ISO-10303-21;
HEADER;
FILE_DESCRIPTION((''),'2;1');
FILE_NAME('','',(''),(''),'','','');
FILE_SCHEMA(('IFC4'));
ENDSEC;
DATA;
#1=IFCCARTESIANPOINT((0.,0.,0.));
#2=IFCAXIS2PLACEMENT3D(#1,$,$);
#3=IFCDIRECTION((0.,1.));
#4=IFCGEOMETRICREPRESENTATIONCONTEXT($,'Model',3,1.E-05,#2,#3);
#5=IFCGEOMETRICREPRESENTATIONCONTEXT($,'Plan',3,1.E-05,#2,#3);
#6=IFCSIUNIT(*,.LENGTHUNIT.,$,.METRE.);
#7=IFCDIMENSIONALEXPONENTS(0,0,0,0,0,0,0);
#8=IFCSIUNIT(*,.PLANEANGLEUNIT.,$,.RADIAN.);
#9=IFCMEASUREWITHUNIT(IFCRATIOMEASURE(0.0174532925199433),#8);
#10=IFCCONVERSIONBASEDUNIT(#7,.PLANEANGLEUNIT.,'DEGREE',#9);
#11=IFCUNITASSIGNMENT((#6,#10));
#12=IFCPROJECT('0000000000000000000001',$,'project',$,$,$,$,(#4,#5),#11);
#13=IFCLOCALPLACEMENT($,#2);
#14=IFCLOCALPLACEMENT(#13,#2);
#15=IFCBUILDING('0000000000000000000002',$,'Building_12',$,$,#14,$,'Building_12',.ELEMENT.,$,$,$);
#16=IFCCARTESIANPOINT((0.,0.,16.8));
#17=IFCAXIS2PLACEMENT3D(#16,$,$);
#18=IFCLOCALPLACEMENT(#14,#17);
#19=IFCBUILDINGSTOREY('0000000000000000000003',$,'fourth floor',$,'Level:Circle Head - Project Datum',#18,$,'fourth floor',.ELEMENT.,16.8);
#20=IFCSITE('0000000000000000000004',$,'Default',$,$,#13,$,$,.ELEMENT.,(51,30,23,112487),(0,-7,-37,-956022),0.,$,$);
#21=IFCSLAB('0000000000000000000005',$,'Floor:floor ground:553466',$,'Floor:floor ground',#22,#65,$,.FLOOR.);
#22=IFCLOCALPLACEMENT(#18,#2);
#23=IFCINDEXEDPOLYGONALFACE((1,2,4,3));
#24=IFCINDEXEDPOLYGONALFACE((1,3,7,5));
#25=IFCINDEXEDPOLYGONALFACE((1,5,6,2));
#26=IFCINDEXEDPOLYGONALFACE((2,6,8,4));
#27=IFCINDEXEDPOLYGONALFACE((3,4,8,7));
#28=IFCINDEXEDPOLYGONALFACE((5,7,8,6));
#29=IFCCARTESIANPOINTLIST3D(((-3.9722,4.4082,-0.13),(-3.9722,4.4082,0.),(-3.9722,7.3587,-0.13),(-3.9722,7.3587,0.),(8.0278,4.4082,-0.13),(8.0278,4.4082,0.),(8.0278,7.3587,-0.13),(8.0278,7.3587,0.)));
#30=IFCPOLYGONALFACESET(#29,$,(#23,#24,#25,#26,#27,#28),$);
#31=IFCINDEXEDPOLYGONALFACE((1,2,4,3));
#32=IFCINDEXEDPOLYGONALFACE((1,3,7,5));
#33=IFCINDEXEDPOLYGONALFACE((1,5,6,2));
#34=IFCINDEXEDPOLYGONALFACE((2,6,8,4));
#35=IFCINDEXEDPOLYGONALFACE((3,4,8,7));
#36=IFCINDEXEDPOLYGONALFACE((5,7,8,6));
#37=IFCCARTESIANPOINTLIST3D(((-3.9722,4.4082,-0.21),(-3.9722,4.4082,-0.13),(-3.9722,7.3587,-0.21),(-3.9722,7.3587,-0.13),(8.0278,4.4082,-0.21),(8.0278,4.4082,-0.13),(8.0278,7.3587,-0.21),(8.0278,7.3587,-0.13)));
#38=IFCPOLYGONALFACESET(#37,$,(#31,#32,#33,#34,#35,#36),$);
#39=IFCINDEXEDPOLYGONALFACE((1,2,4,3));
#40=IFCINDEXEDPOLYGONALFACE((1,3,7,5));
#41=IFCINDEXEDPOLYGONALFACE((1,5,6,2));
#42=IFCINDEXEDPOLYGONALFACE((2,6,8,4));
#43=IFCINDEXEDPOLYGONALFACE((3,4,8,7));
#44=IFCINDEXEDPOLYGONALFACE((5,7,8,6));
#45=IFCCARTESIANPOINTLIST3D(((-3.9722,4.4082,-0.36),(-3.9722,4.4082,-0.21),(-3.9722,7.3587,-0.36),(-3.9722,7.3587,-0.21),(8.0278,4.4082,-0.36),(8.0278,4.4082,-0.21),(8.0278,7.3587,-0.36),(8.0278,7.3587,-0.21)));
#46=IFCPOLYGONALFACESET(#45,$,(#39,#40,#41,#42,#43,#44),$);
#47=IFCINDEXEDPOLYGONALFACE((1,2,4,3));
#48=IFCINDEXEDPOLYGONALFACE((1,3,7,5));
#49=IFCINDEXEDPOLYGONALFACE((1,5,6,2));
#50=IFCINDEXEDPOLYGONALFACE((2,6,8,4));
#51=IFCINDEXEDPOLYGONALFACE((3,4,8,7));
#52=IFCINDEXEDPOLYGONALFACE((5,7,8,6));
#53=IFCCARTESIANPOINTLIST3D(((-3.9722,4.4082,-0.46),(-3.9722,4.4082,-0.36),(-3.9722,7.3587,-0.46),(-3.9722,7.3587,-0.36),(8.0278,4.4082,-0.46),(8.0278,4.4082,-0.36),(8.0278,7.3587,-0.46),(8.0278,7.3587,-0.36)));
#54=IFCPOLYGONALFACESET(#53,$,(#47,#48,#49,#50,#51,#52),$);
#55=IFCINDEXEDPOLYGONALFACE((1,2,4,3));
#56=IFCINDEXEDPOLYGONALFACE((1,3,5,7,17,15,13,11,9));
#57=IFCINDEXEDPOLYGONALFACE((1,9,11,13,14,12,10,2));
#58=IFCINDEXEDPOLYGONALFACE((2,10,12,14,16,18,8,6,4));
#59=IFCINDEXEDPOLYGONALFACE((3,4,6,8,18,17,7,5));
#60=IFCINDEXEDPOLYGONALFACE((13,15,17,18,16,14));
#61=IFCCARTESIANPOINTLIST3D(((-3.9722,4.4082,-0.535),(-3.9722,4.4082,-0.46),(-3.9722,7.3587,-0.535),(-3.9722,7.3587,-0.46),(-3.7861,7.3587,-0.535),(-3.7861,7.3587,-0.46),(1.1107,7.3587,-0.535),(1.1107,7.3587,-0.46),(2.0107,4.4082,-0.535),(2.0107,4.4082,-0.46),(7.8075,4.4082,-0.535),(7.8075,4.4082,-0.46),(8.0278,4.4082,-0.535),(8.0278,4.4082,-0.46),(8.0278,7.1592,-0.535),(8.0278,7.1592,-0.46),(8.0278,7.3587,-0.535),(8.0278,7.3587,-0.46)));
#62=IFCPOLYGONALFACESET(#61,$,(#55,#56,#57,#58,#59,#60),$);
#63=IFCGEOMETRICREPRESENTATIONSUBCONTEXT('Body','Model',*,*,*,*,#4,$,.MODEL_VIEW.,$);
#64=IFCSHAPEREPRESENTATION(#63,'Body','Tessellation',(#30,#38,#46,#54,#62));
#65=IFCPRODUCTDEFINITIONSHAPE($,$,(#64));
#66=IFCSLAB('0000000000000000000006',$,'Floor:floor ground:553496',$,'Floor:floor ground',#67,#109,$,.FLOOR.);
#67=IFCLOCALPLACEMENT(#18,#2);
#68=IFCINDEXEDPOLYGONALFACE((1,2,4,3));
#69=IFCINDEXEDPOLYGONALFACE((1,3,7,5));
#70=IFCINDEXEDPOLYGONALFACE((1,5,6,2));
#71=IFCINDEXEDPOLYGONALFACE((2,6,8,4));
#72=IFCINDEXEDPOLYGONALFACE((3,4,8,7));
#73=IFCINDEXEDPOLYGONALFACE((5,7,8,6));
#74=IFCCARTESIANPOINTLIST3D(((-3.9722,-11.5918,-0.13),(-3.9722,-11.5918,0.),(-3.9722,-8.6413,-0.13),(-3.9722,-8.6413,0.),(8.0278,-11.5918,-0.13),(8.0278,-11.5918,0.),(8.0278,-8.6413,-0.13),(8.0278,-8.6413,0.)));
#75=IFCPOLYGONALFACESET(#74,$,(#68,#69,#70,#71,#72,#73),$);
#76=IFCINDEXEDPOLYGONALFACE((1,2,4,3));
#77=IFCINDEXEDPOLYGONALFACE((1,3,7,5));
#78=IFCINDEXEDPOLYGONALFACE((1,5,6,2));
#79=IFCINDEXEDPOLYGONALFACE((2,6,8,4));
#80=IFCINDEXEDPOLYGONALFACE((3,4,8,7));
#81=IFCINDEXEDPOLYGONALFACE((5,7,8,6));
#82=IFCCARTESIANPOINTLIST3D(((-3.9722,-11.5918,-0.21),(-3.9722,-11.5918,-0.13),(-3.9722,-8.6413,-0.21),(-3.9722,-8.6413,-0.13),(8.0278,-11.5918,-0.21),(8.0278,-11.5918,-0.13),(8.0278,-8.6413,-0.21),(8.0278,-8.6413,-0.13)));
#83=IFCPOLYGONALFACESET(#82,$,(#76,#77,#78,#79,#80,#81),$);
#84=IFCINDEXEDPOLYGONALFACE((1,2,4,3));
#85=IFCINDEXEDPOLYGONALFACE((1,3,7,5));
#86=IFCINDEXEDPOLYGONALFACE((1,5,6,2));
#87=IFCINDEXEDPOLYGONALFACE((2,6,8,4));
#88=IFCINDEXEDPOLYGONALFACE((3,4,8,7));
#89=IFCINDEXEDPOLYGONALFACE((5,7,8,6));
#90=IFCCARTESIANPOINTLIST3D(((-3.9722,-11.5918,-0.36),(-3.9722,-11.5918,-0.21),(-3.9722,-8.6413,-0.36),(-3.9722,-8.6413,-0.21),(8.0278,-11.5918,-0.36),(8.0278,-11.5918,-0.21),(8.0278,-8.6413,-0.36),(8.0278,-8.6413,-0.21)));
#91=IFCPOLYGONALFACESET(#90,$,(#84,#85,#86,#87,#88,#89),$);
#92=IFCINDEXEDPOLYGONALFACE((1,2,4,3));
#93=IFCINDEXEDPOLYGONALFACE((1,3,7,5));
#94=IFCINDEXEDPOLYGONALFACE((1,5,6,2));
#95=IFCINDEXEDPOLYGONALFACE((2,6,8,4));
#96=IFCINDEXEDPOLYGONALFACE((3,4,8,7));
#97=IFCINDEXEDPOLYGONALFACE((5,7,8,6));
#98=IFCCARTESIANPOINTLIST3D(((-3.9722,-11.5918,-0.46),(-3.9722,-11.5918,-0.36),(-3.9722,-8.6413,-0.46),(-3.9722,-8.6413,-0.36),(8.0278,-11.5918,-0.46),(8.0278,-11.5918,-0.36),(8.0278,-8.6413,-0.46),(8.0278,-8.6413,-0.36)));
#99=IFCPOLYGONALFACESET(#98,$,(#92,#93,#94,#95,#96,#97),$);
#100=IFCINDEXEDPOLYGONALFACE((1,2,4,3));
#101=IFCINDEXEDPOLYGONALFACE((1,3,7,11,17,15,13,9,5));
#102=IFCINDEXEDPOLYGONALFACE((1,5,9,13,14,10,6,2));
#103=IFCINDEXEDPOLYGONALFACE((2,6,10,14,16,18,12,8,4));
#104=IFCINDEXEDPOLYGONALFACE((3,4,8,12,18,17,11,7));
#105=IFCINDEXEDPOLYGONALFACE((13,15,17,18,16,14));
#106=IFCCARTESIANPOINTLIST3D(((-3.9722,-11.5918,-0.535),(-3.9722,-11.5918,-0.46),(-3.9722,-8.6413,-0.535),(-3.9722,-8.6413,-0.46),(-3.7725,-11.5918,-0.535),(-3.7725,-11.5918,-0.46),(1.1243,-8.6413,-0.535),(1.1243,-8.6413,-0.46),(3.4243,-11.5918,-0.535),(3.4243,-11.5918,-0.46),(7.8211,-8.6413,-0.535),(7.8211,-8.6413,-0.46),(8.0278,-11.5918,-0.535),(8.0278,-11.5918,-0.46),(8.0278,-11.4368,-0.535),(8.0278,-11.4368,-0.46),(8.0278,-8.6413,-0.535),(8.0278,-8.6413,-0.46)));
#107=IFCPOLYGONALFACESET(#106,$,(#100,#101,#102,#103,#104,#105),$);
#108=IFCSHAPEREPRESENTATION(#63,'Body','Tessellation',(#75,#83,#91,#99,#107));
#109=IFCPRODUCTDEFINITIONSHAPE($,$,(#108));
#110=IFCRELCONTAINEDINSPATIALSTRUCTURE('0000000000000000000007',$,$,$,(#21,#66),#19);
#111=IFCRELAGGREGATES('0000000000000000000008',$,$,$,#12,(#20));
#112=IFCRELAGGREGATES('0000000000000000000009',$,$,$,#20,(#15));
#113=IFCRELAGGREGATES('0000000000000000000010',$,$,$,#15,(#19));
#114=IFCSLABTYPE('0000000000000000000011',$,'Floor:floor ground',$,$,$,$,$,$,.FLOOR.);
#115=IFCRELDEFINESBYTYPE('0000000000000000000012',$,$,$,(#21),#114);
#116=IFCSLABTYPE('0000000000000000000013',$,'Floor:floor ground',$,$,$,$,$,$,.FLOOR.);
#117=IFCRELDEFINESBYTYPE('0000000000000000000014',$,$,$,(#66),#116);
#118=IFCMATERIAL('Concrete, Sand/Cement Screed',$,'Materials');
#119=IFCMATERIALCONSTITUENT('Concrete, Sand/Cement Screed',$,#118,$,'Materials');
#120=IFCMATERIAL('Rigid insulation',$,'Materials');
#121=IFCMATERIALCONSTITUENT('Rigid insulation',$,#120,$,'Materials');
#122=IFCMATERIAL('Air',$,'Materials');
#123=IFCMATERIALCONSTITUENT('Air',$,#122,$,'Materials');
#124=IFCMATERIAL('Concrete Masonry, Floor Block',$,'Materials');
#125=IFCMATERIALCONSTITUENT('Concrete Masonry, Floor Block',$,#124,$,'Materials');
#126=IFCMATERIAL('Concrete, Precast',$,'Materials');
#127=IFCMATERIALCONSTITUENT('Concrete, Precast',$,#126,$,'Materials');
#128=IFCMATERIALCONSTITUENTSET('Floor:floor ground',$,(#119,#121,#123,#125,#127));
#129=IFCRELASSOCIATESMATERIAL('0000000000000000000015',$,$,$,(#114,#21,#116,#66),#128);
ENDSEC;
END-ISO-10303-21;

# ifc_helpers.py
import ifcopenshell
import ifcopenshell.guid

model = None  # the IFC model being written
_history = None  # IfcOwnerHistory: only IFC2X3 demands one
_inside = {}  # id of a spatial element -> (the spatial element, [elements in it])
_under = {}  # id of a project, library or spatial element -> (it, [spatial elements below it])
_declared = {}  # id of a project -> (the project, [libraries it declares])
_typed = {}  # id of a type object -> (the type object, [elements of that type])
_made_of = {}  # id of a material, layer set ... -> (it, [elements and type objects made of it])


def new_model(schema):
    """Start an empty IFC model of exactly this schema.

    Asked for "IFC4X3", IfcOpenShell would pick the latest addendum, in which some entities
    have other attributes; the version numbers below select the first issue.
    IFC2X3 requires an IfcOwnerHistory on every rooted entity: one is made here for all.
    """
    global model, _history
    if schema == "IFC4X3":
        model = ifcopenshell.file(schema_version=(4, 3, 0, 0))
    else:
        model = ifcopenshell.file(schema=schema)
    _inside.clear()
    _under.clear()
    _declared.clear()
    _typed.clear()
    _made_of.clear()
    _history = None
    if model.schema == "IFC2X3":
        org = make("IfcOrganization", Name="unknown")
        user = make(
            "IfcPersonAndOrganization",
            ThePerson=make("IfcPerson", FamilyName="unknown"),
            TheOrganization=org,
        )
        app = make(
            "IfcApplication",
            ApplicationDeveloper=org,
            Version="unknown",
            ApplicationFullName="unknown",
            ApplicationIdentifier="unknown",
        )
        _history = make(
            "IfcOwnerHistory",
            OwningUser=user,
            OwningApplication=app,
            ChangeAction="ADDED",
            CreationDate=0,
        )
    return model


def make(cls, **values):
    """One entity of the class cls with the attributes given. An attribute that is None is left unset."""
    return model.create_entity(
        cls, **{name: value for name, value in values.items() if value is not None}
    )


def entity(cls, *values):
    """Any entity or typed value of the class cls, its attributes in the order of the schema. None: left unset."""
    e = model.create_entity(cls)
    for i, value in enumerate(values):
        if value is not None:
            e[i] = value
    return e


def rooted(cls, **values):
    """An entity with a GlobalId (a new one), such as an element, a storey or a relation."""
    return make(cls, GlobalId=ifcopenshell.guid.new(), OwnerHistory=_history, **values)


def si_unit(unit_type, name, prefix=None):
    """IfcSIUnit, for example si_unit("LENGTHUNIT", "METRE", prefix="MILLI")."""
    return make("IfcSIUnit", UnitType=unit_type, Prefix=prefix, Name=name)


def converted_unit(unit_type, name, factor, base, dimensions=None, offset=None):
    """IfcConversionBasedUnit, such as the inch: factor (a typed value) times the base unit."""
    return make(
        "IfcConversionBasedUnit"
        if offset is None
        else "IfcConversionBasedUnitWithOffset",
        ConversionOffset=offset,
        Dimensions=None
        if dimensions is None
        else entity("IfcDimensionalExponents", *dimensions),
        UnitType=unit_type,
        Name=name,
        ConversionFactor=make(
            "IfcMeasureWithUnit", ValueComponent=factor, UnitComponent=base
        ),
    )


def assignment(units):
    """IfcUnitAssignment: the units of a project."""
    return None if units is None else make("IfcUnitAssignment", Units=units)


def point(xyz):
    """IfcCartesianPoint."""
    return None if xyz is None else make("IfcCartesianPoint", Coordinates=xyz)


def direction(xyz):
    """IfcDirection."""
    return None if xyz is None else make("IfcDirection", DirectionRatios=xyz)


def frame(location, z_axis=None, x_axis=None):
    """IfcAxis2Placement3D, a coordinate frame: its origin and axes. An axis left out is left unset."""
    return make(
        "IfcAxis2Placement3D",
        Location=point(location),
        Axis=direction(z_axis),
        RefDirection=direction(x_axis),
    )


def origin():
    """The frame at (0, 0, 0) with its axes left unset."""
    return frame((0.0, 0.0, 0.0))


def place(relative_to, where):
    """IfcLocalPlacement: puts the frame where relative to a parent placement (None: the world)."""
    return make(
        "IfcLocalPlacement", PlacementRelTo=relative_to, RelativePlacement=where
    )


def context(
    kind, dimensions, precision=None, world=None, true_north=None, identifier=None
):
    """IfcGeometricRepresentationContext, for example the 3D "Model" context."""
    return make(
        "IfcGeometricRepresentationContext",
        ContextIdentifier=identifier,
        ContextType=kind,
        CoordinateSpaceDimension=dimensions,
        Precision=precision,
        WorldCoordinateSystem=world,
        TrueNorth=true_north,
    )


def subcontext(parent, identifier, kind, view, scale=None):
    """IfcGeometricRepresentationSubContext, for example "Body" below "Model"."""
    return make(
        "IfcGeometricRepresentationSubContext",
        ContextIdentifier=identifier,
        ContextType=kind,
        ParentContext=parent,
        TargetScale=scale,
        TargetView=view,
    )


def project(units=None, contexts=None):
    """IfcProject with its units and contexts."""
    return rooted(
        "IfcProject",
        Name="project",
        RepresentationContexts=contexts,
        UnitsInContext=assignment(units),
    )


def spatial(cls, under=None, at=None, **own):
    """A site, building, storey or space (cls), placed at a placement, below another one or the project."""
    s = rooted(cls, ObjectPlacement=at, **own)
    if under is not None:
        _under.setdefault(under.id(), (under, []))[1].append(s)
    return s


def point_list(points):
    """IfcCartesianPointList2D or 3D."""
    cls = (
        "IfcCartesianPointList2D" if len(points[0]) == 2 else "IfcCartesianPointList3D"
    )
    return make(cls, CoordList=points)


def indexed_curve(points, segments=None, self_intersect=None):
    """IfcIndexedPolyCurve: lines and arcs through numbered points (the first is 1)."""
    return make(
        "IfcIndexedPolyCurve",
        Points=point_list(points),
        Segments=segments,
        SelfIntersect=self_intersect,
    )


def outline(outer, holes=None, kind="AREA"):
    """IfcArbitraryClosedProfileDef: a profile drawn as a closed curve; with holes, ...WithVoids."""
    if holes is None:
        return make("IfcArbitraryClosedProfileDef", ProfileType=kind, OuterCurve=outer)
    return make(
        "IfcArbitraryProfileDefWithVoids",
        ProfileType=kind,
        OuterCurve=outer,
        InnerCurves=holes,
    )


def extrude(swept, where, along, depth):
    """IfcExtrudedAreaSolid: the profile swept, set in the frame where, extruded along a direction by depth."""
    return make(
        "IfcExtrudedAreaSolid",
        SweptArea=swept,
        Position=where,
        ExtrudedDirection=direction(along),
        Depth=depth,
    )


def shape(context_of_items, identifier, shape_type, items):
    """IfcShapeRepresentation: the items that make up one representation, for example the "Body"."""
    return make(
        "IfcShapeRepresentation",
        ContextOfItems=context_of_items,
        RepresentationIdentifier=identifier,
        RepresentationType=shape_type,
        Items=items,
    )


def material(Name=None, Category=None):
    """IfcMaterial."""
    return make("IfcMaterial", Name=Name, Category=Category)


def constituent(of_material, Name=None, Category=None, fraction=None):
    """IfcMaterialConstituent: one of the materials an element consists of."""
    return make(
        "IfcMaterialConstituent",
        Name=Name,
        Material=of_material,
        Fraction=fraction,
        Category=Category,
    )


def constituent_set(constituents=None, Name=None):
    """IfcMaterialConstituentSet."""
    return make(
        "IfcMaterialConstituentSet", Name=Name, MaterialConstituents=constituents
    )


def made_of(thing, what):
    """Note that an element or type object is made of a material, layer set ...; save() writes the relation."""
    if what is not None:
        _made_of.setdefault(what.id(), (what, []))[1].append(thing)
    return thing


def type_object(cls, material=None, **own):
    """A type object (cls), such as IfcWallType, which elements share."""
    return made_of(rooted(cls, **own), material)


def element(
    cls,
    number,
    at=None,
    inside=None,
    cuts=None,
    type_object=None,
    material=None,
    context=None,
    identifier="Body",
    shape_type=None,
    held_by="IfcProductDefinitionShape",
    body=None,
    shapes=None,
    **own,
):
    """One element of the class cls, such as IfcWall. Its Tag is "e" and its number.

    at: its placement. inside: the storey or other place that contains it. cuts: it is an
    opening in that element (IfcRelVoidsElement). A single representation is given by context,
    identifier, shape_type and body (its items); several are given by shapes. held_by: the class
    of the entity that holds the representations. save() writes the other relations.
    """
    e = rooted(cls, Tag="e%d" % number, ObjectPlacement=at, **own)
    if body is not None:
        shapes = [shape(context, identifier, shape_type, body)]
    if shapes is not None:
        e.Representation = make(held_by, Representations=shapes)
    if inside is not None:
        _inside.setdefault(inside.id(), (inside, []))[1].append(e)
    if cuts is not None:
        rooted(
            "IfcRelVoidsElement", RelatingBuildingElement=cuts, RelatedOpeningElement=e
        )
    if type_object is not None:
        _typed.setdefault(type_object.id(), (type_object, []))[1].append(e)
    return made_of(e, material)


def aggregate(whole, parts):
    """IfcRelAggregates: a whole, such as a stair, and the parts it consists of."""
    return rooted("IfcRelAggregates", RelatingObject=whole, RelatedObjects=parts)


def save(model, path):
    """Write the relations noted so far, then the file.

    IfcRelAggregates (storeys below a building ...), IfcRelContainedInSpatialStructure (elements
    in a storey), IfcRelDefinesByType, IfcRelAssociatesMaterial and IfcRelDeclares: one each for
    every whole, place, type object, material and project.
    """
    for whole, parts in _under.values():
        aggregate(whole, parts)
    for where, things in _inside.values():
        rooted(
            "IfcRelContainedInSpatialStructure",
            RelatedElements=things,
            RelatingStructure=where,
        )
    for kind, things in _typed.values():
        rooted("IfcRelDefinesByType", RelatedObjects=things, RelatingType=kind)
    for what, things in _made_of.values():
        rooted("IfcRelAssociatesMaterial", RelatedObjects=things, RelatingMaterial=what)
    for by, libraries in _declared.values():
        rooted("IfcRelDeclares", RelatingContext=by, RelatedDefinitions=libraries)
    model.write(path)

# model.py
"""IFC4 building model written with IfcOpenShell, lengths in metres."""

from ifc_helpers import new_model, entity, si_unit, converted_unit, direction, frame, origin, place, context, subcontext, project, spatial, indexed_curve, outline, extrude, material, constituent, constituent_set, type_object, element, save


model = new_model("IFC4")

# Units and contexts
model_context = context("Model", 3, precision=1e-05, world=origin(), true_north=direction((0.0, 1.0)))
plan_context = context("Plan", 3, precision=1e-05, world=origin(), true_north=direction((0.0, 1.0)))
body_context = subcontext(model_context, "Body", "Model", "MODEL_VIEW")
ifc_project = project(units=[si_unit("LENGTHUNIT", "METRE"), converted_unit("PLANEANGLEUNIT", "DEGREE", entity("IfcRatioMeasure", 0.0174532925199433), si_unit("PLANEANGLEUNIT", "RADIAN"), dimensions=[0, 0, 0, 0, 0, 0, 0])], contexts=[model_context, plan_context])

# Site, building, storey
site_placement = place(None, origin())
site = spatial("IfcSite", under=ifc_project, at=site_placement, Name="Default", CompositionType="ELEMENT", RefLatitude=(51, 30, 23, 112487), RefLongitude=(0, -7, -37, -956022), RefElevation=0.0)
building_placement = place(site_placement, origin())
building = spatial("IfcBuilding", under=site, at=building_placement, Name="Building_12", LongName="Building_12", CompositionType="ELEMENT")
storey_placement = place(building_placement, frame((0.0, 0.0, 16.8)))
storey = spatial("IfcBuildingStorey", under=building, at=storey_placement, Name="fourth floor", ObjectType="Level:Circle Head - Project Datum", LongName="fourth floor", CompositionType="ELEMENT", Elevation=16.8)

# Slabs
ifc_material_1 = material(Name="Concrete, Sand/Cement Screed", Category="Materials")
ifc_constituent_1 = constituent(ifc_material_1, Name="Concrete, Sand/Cement Screed", Category="Materials")
ifc_material_2 = material(Name="Rigid insulation", Category="Materials")
ifc_constituent_2 = constituent(ifc_material_2, Name="Rigid insulation", Category="Materials")
ifc_material_3 = material(Name="Air", Category="Materials")
ifc_constituent_3 = constituent(ifc_material_3, Name="Air", Category="Materials")
ifc_material_4 = material(Name="Concrete Masonry, Floor Block", Category="Materials")
ifc_constituent_4 = constituent(ifc_material_4, Name="Concrete Masonry, Floor Block", Category="Materials")
ifc_material_5 = material(Name="Concrete, Precast", Category="Materials")
ifc_constituent_5 = constituent(ifc_material_5, Name="Concrete, Precast", Category="Materials")
ifc_constituent_set_1 = constituent_set(constituents=[ifc_constituent_1, ifc_constituent_2, ifc_constituent_3, ifc_constituent_4, ifc_constituent_5], Name="Floor:floor ground")
slab_type_1 = type_object("IfcSlabType", Name="Floor:floor ground", PredefinedType="FLOOR", material=ifc_constituent_set_1)
slab_1_placement = place(storey_placement, origin())
element("IfcSlab", 1, at=slab_1_placement, inside=storey, type_object=slab_type_1, material=ifc_constituent_set_1, Name="Floor:floor ground:553466", ObjectType="Floor:floor ground", PredefinedType="FLOOR", context=body_context, shape_type="SweptSolid", body=[
    extrude(outline(indexed_curve([(-6.0, -1.4753), (6.0, -1.4753), (6.0, 1.4753), (-6.0, 1.4753), (-6.0, -1.4753)], self_intersect=False)), frame((2.0278, 5.8834, -0.13), z_axis=(0.0, 0.0, 1.0), x_axis=(-1.0, 0.0, 0.0)), (0.0, 0.0, 1.0), 0.13),
    extrude(outline(indexed_curve([(-6.0, -1.4753), (6.0, -1.4753), (6.0, 1.4753), (-6.0, 1.4753), (-6.0, -1.4753)], self_intersect=False)), frame((2.0278, 5.8834, -0.21), z_axis=(0.0, 0.0, 1.0), x_axis=(-1.0, 0.0, 0.0)), (0.0, 0.0, 1.0), 0.08),
    extrude(outline(indexed_curve([(-6.0, -1.4753), (6.0, -1.4753), (6.0, 1.4753), (-6.0, 1.4753), (-6.0, -1.4753)], self_intersect=False)), frame((2.0278, 5.8834, -0.36), z_axis=(0.0, 0.0, 1.0), x_axis=(-1.0, 0.0, 0.0)), (0.0, 0.0, 1.0), 0.15),
    extrude(outline(indexed_curve([(-6.0, -1.4753), (6.0, -1.4753), (6.0, 1.4753), (-6.0, 1.4753), (-6.0, -1.4753)], self_intersect=False)), frame((2.0278, 5.8834, -0.46), z_axis=(0.0, 0.0, 1.0), x_axis=(-1.0, 0.0, 0.0)), (0.0, 0.0, 1.0), 0.1),
    extrude(outline(indexed_curve([(-5.4409, -1.3335), (1.4762, -1.3335), (6.373, -1.3335), (6.5591, -1.3335), (6.5591, 1.617), (0.5762, 1.617), (-5.2206, 1.617), (-5.4409, 1.617), (-5.4409, -1.134), (-5.4409, -1.3335)], self_intersect=False)), frame((2.5869, 6.0252, -0.535), z_axis=(0.0, 0.0, 1.0), x_axis=(-1.0, 0.0, 0.0)), (0.0, 0.0, 1.0), 0.075),
])
slab_type_2 = type_object("IfcSlabType", Name="Floor:floor ground", PredefinedType="FLOOR", material=ifc_constituent_set_1)
slab_2_placement = place(storey_placement, origin())
element("IfcSlab", 2, at=slab_2_placement, inside=storey, type_object=slab_type_2, material=ifc_constituent_set_1, Name="Floor:floor ground:553496", ObjectType="Floor:floor ground", PredefinedType="FLOOR", context=body_context, shape_type="SweptSolid", body=[
    extrude(outline(indexed_curve([(-6.0, -1.4753), (6.0, -1.4753), (6.0, 1.4753), (-6.0, 1.4753), (-6.0, -1.4753)], self_intersect=False)), frame((2.0278, -10.1166, -0.13), z_axis=(0.0, 0.0, 1.0), x_axis=(-1.0, 0.0, 0.0)), (0.0, 0.0, 1.0), 0.13),
    extrude(outline(indexed_curve([(-6.0, -1.4753), (6.0, -1.4753), (6.0, 1.4753), (-6.0, 1.4753), (-6.0, -1.4753)], self_intersect=False)), frame((2.0278, -10.1166, -0.21), z_axis=(0.0, 0.0, 1.0), x_axis=(-1.0, 0.0, 0.0)), (0.0, 0.0, 1.0), 0.08),
    extrude(outline(indexed_curve([(-6.0, -1.4753), (6.0, -1.4753), (6.0, 1.4753), (-6.0, 1.4753), (-6.0, -1.4753)], self_intersect=False)), frame((2.0278, -10.1166, -0.36), z_axis=(0.0, 0.0, 1.0), x_axis=(-1.0, 0.0, 0.0)), (0.0, 0.0, 1.0), 0.15),
    extrude(outline(indexed_curve([(-6.0, -1.4753), (6.0, -1.4753), (6.0, 1.4753), (-6.0, 1.4753), (-6.0, -1.4753)], self_intersect=False)), frame((2.0278, -10.1166, -0.46), z_axis=(0.0, 0.0, 1.0), x_axis=(-1.0, 0.0, 0.0)), (0.0, 0.0, 1.0), 0.1),
    extrude(outline(indexed_curve([(-5.2793, -1.6219), (-5.0726, -1.6219), (1.6242, -1.6219), (6.7207, -1.6219), (6.7207, 1.3286), (6.521, 1.3286), (-0.6758, 1.3286), (-5.2793, 1.3286), (-5.2793, 1.1735), (-5.2793, -1.6219)], self_intersect=False)), frame((2.7485, -10.2633, -0.535), z_axis=(0.0, 0.0, 1.0), x_axis=(-1.0, 0.0, 0.0)), (0.0, 0.0, 1.0), 0.075),
])

save(model, "model.ifc")
